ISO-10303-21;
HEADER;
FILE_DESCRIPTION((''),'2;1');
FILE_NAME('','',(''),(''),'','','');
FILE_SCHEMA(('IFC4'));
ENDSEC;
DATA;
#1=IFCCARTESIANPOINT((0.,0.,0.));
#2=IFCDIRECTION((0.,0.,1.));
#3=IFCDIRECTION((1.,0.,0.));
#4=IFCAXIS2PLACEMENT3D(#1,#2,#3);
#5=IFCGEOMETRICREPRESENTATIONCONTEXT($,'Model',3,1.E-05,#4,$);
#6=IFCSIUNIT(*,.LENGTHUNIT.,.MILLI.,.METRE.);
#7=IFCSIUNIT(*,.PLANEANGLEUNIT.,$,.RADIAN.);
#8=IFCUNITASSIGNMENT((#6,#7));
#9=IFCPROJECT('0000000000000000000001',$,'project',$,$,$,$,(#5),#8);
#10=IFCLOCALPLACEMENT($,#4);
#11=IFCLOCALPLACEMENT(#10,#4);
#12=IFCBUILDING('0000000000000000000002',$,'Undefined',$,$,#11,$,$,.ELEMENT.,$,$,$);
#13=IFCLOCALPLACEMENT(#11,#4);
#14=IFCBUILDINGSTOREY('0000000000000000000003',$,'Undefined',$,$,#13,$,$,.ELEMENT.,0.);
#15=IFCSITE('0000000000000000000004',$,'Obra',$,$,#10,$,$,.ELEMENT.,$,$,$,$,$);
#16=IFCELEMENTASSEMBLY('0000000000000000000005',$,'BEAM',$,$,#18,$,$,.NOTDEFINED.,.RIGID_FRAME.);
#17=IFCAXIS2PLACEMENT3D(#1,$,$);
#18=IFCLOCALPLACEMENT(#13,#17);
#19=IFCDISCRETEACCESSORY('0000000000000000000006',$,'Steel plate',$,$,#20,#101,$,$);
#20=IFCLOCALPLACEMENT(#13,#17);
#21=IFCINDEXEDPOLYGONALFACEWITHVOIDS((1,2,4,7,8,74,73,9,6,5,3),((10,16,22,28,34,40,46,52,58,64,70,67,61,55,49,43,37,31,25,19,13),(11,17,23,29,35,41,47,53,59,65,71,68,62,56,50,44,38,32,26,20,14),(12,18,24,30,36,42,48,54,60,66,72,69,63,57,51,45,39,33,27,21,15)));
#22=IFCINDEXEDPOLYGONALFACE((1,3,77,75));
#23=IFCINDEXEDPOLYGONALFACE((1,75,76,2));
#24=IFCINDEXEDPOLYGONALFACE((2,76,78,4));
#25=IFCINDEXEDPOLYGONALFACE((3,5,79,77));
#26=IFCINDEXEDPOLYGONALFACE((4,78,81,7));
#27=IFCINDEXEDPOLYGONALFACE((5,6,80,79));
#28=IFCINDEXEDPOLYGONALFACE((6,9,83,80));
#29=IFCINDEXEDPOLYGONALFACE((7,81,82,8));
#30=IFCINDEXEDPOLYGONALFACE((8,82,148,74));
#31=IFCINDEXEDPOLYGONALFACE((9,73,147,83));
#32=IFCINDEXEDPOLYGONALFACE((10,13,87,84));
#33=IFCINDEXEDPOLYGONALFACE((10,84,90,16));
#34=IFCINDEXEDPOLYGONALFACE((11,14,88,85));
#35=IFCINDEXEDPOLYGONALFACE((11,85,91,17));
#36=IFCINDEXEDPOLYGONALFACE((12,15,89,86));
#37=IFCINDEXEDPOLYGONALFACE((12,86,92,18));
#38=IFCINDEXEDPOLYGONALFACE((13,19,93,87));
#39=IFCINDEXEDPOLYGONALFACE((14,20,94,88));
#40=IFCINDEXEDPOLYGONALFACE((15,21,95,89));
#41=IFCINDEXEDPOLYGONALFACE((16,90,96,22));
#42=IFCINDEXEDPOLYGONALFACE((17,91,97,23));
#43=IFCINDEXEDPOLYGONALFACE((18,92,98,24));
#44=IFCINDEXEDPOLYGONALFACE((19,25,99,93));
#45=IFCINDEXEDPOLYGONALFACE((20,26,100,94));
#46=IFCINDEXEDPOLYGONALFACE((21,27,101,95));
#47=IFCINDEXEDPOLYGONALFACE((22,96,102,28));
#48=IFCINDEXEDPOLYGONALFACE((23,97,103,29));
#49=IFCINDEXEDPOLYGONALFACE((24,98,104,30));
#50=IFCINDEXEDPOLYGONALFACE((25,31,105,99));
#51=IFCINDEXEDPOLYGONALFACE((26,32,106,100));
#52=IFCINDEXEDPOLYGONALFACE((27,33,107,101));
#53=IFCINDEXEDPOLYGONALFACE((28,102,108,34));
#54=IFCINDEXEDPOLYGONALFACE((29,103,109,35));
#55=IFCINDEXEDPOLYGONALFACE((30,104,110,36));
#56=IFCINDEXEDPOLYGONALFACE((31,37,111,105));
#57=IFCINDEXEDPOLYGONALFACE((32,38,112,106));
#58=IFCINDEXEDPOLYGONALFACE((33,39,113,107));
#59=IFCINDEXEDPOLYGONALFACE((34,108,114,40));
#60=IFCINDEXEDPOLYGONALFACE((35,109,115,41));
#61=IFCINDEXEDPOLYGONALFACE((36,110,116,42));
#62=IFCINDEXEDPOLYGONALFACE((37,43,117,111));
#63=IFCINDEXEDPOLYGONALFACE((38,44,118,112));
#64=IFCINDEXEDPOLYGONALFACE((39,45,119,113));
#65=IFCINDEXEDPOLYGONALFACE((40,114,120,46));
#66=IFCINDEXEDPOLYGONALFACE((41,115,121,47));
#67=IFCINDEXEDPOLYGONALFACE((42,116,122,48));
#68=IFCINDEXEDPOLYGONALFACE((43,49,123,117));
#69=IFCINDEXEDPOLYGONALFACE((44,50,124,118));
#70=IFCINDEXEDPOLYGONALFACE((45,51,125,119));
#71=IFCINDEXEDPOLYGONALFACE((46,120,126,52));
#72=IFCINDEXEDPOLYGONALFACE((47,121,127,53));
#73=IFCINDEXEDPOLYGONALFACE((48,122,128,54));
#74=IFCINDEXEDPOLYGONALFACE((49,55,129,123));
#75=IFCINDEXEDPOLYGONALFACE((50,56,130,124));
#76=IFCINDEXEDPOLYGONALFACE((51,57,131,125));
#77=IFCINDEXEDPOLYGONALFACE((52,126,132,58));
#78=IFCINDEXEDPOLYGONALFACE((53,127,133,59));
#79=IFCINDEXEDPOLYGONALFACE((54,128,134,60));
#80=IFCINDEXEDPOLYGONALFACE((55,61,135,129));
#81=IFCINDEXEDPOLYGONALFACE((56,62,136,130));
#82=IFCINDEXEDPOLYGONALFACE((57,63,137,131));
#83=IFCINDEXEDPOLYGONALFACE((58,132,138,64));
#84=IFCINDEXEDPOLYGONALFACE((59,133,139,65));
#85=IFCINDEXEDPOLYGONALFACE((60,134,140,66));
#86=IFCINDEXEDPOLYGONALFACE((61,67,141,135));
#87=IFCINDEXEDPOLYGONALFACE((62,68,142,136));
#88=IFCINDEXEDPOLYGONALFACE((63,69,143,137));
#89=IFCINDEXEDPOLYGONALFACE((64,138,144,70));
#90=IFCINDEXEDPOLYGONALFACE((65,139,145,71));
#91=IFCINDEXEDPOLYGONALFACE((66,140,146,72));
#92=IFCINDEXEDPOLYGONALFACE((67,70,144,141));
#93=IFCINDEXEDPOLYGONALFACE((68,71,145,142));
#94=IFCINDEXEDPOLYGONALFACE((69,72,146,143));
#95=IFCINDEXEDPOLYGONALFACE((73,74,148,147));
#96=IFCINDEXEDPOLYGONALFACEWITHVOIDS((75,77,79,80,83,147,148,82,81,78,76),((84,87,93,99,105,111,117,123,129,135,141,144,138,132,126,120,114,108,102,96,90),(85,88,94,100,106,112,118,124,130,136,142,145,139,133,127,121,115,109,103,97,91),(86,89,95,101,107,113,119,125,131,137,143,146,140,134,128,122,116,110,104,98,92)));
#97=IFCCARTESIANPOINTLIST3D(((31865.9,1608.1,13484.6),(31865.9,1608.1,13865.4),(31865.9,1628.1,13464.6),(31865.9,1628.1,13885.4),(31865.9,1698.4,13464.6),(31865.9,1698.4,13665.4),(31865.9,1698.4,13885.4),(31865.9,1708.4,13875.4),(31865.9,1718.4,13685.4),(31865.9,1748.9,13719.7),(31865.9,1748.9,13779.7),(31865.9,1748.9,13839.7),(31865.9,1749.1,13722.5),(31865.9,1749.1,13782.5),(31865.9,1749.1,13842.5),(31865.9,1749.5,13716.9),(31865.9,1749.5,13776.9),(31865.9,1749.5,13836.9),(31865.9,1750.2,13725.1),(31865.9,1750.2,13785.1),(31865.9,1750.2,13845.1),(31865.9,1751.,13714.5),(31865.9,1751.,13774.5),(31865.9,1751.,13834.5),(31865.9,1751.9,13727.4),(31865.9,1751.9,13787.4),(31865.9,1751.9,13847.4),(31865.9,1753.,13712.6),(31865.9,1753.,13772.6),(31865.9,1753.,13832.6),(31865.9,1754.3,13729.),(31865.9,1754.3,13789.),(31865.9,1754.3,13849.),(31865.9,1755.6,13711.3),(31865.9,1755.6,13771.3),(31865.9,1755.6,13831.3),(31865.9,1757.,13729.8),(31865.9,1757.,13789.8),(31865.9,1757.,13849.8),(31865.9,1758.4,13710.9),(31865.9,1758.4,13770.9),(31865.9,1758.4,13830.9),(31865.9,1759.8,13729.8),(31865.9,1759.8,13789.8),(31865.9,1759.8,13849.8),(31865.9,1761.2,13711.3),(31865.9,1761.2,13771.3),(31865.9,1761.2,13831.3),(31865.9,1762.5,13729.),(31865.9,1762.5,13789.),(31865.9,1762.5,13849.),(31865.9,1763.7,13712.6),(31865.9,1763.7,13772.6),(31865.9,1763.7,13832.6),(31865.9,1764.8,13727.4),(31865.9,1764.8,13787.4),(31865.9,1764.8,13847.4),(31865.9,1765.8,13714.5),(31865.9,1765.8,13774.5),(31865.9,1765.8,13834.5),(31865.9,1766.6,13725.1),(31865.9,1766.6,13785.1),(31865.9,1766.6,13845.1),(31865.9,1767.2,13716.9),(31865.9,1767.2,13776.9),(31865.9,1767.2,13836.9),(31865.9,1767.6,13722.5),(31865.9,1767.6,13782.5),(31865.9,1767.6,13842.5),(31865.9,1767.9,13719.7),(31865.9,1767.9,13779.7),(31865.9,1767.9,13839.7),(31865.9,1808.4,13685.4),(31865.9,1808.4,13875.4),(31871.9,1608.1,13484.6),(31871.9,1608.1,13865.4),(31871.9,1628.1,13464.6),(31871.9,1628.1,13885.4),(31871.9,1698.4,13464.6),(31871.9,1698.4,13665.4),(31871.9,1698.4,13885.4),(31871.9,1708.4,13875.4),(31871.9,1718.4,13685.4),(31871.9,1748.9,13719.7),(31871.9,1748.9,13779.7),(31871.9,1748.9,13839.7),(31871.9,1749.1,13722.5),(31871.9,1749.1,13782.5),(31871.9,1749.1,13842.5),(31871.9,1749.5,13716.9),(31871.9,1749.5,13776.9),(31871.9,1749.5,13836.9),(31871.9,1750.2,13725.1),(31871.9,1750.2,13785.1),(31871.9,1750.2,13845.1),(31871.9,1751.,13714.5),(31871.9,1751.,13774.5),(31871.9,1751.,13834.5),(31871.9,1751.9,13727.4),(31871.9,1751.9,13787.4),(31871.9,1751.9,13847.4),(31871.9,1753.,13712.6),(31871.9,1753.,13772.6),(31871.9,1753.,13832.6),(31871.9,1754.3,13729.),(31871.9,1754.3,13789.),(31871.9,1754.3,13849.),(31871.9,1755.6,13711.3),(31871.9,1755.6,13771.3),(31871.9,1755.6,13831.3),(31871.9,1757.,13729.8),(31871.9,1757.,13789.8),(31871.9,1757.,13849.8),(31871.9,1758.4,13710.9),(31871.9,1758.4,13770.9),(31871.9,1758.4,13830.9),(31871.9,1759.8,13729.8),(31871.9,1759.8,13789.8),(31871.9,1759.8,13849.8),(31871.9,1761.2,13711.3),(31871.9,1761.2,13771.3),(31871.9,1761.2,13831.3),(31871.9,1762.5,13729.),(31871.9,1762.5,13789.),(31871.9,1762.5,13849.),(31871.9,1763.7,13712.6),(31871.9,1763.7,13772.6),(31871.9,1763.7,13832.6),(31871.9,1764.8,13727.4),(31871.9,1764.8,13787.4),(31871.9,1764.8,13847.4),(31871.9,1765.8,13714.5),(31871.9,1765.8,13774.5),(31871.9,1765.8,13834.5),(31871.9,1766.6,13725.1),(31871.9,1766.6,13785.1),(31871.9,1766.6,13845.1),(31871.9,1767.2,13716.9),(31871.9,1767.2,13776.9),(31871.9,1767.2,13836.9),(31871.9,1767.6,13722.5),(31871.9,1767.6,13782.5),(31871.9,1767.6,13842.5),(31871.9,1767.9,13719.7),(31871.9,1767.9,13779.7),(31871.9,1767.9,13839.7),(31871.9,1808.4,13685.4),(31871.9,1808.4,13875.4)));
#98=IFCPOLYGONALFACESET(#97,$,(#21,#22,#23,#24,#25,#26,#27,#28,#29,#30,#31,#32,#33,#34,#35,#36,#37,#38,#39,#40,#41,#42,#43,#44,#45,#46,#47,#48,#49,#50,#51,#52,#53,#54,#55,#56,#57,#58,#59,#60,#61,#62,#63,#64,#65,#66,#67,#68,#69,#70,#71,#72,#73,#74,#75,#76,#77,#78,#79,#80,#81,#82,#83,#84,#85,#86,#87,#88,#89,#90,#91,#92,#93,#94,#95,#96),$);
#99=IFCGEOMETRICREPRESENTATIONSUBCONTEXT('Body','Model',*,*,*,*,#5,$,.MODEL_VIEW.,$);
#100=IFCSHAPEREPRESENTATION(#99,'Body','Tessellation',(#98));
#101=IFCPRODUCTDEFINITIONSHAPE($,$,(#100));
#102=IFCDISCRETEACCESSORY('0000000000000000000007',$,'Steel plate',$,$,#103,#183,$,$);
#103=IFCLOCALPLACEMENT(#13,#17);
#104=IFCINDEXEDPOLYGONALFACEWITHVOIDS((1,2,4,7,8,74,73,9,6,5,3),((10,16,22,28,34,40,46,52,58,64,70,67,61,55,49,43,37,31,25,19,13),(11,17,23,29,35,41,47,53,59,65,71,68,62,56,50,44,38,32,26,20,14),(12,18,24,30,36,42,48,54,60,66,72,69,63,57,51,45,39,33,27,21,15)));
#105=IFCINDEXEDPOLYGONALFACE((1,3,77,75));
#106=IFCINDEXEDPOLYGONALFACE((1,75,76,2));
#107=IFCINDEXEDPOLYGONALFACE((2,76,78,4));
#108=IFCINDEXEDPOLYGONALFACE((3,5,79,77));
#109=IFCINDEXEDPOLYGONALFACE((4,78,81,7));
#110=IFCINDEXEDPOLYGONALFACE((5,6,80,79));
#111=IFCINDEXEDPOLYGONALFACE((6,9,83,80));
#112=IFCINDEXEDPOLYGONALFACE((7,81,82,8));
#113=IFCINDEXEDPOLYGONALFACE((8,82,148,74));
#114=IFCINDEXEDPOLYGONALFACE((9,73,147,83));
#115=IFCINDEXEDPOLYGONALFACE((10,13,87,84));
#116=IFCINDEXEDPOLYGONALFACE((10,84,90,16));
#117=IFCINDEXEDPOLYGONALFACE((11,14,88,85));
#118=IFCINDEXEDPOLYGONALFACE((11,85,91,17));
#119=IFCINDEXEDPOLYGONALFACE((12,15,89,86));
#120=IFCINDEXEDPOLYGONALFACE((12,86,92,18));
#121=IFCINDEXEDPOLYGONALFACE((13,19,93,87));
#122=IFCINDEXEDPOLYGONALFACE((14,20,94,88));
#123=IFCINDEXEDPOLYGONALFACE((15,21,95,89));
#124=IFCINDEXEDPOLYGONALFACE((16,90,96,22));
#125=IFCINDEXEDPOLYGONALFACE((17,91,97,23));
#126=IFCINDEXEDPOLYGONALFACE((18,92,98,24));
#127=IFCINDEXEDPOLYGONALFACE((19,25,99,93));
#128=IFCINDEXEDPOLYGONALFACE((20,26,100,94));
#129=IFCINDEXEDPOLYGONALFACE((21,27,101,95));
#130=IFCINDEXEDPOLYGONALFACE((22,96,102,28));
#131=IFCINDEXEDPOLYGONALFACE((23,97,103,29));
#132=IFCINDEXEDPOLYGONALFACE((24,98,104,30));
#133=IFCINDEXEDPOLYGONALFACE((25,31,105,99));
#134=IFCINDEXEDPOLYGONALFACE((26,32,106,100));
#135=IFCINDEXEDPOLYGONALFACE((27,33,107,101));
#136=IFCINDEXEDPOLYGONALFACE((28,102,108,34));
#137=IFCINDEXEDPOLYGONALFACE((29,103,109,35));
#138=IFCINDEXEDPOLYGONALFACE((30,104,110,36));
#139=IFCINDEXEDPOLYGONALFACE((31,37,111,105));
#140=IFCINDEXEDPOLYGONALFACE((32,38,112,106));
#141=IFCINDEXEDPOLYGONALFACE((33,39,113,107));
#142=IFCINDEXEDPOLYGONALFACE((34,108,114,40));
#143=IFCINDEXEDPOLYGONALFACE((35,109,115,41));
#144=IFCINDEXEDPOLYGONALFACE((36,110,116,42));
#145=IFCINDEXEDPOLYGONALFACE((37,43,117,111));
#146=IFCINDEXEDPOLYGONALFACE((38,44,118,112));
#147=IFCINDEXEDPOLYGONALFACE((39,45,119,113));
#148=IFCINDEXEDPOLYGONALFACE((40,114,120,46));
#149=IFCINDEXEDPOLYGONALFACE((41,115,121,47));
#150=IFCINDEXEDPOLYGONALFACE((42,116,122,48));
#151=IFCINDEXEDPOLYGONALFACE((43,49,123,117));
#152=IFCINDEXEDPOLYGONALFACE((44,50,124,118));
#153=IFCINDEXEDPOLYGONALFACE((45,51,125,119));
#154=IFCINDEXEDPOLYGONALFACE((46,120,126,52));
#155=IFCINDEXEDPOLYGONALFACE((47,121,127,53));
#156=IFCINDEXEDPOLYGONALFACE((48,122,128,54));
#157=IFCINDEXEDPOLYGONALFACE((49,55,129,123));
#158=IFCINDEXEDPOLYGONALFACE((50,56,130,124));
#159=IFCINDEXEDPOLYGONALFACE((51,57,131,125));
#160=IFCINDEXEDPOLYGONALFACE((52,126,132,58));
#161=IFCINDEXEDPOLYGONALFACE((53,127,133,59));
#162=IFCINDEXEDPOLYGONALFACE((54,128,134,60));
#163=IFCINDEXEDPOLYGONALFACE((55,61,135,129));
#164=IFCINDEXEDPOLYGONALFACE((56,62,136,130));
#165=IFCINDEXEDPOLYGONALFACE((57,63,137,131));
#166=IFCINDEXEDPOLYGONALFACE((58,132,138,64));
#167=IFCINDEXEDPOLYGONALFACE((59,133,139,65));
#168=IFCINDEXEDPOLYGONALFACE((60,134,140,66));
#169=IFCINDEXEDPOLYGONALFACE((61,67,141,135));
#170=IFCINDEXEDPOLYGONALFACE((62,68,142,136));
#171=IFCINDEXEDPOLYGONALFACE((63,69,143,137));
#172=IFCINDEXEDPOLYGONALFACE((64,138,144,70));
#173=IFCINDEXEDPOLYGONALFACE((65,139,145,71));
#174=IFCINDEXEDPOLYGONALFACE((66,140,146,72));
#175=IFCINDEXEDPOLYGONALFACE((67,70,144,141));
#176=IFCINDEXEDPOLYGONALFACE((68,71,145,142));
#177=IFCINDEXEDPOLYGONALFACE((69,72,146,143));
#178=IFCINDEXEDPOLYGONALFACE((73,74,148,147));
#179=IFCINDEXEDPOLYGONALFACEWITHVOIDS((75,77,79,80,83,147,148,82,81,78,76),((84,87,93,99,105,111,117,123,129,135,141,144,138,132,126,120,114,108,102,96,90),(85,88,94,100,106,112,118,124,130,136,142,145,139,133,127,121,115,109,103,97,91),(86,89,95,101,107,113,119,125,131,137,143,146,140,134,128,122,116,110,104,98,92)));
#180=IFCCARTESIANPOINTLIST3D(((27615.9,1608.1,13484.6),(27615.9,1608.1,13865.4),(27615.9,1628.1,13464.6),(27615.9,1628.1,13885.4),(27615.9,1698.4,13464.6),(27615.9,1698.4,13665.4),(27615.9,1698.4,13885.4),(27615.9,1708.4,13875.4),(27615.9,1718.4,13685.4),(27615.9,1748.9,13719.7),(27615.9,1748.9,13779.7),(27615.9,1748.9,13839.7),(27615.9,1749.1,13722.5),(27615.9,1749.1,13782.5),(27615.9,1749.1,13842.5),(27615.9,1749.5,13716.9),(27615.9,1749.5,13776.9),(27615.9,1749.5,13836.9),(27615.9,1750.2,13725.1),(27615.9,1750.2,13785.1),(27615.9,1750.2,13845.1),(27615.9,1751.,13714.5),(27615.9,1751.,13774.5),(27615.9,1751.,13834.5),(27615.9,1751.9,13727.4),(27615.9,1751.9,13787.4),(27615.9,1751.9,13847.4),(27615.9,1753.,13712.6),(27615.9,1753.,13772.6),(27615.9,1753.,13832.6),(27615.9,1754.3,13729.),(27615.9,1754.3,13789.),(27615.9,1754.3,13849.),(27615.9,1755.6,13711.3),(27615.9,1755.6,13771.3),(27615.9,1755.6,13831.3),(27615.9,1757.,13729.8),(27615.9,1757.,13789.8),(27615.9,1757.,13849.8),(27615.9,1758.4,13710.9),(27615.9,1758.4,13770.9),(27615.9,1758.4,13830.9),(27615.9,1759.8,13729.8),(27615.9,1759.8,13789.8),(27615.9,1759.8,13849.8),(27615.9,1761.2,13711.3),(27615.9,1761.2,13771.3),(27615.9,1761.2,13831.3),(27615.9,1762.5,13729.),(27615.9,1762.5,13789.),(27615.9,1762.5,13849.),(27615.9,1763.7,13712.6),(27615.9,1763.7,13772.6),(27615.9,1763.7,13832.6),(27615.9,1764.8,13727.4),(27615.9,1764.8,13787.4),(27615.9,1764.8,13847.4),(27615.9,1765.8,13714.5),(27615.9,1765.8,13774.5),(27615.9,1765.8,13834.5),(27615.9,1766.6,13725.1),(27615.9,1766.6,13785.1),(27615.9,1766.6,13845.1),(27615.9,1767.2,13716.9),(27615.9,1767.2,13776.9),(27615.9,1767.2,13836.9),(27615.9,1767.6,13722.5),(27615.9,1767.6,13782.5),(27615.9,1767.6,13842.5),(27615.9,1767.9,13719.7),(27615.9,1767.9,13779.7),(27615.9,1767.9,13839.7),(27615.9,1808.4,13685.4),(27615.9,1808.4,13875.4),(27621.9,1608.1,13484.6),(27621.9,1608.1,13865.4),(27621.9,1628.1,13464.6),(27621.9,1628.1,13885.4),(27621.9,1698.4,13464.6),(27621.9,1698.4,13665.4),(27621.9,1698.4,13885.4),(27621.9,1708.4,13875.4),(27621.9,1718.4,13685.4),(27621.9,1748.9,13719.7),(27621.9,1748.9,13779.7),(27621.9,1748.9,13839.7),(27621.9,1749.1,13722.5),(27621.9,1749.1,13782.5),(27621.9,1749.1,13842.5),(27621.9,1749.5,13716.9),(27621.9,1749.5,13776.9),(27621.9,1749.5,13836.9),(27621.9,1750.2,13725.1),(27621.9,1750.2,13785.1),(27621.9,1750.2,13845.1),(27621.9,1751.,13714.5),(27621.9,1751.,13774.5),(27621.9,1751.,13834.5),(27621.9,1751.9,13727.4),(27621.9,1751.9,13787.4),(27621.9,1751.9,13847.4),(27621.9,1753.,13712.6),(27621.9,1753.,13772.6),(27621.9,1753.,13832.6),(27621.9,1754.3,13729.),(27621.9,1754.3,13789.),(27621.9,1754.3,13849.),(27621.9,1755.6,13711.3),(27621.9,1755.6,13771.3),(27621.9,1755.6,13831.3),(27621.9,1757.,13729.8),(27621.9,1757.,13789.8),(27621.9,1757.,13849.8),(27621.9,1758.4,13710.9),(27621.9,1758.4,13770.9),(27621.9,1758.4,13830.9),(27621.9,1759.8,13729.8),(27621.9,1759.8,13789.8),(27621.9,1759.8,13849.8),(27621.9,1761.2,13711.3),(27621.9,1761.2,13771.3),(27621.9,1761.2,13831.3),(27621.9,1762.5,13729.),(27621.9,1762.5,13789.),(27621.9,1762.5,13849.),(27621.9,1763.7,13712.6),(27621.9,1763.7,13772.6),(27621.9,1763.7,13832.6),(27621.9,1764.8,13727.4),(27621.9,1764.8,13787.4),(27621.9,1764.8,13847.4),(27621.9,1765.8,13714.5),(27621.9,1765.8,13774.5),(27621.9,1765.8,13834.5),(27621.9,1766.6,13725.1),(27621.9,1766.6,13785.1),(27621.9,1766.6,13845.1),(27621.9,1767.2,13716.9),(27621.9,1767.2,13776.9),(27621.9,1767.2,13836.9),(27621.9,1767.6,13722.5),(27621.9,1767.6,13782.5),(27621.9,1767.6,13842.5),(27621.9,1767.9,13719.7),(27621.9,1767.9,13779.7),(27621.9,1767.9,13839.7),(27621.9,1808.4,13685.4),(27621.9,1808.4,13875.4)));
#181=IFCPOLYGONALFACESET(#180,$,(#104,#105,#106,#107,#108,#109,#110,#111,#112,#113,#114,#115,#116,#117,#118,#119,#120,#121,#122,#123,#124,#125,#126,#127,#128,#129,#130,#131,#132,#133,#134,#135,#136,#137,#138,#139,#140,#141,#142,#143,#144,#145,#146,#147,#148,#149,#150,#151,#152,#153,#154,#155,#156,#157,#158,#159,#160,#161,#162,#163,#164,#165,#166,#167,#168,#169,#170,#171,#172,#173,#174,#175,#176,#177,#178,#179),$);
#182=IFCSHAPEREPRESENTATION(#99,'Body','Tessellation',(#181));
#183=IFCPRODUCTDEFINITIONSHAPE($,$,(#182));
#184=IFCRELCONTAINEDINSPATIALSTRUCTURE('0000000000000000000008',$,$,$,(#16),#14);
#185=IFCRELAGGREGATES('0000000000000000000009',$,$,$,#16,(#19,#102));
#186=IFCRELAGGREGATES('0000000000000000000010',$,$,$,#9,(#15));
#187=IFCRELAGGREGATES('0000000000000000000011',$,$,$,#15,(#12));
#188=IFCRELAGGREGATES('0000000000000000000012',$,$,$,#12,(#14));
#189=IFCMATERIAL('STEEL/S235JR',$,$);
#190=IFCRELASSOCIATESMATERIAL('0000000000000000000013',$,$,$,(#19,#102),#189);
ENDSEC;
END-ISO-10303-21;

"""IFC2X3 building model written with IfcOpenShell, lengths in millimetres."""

from ifc_helpers import new_model, si_unit, frame, origin_with_axes, origin_2d_with_axis, place, context, subcontext, project, spatial, polyline, circle, outline, extrude, source, transform, mapped, material, element, aggregate, save


model = new_model("IFC2X3")

# Units and contexts
model_context = context("Model", 3, precision=1e-05, world=origin_with_axes())
body_context = subcontext(model_context, "Body", "Model", "MODEL_VIEW")
ifc_project = project(units=[si_unit("LENGTHUNIT", "METRE", prefix="MILLI"), si_unit("PLANEANGLEUNIT", "RADIAN")], contexts=[model_context])

# Site, building, storey
site_placement = place(None, origin_with_axes())
site = spatial("IfcSite", under=ifc_project, at=site_placement, Name="Obra", CompositionType="ELEMENT")
building_placement = place(site_placement, origin_with_axes())
building = spatial("IfcBuilding", under=site, at=building_placement, Name="Undefined", CompositionType="ELEMENT")
storey_placement = place(building_placement, origin_with_axes())
storey = spatial("IfcBuildingStorey", under=building, at=storey_placement, Name="Undefined", CompositionType="ELEMENT", Elevation=0.0)

# Shared definitions
ifc_material_1 = material(Name="STEEL/S235JR")

# Element assembly, discrete accessories, openings
assembly_1_placement = place(storey_placement, origin_with_axes())
assembly_1 = element("IfcElementAssembly", 1, at=assembly_1_placement, inside=storey, Name="BEAM", AssemblyPlace="NOTDEFINED", PredefinedType="RIGID_FRAME")
discrete_accessory_1_placement = place(assembly_1_placement, frame((31868.9, 1608.1, 13484.6), z_axis=(1.0, 0.0, 0.0), x_axis=(-0.000001, 0.707107, -0.707107)))
discrete_accessory_1 = element("IfcDiscreteAccessory", 2, at=discrete_accessory_1_placement, material=ifc_material_1, Name="Steel plate", context=body_context, shape_type="SweptSolid", body=[
    extrude(outline(polyline([(0.0, 0.0), (28.3, 0.0), (78.0, 49.7), (-64.0, 191.7), (-64.0, 220.0), (-0.4, 283.6), (-134.7, 418.0), (-205.4, 347.3), (-219.6, 347.3), (-219.6, 347.3), (-269.3, 297.6), (-269.3, 269.3), (0.0, 0.0)])), frame((0.0, 0.0, -3.0), z_axis=(0.0, 0.0, 1.0), x_axis=(1.0, 0.0, 0.0)), (0.0, 0.0, 1.0), 6.0),
])
shared_shape_1 = source(origin_with_axes(), body_context, "Body", "SweptSolid", [
    extrude(circle(Radius=9.5, at=origin_2d_with_axis()), frame((0.0, 3.0, 0.0), z_axis=(0.0, 1.0, 0.0), x_axis=(1.0, 0.0, 0.0)), (0.0, 0.0, 1.0), 6.2),
])
opening_1_placement = place(assembly_1_placement, frame((31875.0, 1708.4, 13875.4), z_axis=(0.0, 1.0, 0.0), x_axis=(0.0, 0.0, -1.0)))
element("IfcOpeningElement", 3, at=opening_1_placement, cuts=discrete_accessory_1, ObjectType="Opening", context=body_context, shape_type="MappedRepresentation", body=[
    mapped(shared_shape_1, transform((35.0, 0.0, 50.0))),
    mapped(shared_shape_1, transform((95.0, 0.0, 50.0))),
    mapped(shared_shape_1, transform((155.0, 0.0, 50.0))),
])
discrete_accessory_2_placement = place(assembly_1_placement, frame((27618.9, 1608.1, 13484.6), z_axis=(1.0, 0.0, 0.0), x_axis=(-0.000001, 0.707107, -0.707107)))
discrete_accessory_2 = element("IfcDiscreteAccessory", 4, at=discrete_accessory_2_placement, material=ifc_material_1, Name="Steel plate", context=body_context, shape_type="SweptSolid", body=[
    extrude(outline(polyline([(0.0, 0.0), (28.3, 0.0), (78.0, 49.7), (-64.0, 191.7), (-64.0, 220.0), (-0.4, 283.6), (-134.7, 418.0), (-205.4, 347.3), (-219.6, 347.3), (-219.6, 347.3), (-269.3, 297.6), (-269.3, 269.3), (0.0, 0.0)])), frame((0.0, 0.0, -3.0), z_axis=(0.0, 0.0, 1.0), x_axis=(1.0, 0.0, 0.0)), (0.0, 0.0, 1.0), 6.0),
])
opening_2_placement = place(assembly_1_placement, frame((27625.0, 1708.4, 13875.4), z_axis=(0.0, 1.0, 0.0), x_axis=(0.0, 0.0, -1.0)))
element("IfcOpeningElement", 5, at=opening_2_placement, cuts=discrete_accessory_2, ObjectType="Opening", context=body_context, shape_type="MappedRepresentation", body=[
    mapped(shared_shape_1, transform((35.0, 0.0, 50.0))),
    mapped(shared_shape_1, transform((95.0, 0.0, 50.0))),
    mapped(shared_shape_1, transform((155.0, 0.0, 50.0))),
])

aggregate(assembly_1, [discrete_accessory_1, discrete_accessory_2])

save(model, "model.ifc")
